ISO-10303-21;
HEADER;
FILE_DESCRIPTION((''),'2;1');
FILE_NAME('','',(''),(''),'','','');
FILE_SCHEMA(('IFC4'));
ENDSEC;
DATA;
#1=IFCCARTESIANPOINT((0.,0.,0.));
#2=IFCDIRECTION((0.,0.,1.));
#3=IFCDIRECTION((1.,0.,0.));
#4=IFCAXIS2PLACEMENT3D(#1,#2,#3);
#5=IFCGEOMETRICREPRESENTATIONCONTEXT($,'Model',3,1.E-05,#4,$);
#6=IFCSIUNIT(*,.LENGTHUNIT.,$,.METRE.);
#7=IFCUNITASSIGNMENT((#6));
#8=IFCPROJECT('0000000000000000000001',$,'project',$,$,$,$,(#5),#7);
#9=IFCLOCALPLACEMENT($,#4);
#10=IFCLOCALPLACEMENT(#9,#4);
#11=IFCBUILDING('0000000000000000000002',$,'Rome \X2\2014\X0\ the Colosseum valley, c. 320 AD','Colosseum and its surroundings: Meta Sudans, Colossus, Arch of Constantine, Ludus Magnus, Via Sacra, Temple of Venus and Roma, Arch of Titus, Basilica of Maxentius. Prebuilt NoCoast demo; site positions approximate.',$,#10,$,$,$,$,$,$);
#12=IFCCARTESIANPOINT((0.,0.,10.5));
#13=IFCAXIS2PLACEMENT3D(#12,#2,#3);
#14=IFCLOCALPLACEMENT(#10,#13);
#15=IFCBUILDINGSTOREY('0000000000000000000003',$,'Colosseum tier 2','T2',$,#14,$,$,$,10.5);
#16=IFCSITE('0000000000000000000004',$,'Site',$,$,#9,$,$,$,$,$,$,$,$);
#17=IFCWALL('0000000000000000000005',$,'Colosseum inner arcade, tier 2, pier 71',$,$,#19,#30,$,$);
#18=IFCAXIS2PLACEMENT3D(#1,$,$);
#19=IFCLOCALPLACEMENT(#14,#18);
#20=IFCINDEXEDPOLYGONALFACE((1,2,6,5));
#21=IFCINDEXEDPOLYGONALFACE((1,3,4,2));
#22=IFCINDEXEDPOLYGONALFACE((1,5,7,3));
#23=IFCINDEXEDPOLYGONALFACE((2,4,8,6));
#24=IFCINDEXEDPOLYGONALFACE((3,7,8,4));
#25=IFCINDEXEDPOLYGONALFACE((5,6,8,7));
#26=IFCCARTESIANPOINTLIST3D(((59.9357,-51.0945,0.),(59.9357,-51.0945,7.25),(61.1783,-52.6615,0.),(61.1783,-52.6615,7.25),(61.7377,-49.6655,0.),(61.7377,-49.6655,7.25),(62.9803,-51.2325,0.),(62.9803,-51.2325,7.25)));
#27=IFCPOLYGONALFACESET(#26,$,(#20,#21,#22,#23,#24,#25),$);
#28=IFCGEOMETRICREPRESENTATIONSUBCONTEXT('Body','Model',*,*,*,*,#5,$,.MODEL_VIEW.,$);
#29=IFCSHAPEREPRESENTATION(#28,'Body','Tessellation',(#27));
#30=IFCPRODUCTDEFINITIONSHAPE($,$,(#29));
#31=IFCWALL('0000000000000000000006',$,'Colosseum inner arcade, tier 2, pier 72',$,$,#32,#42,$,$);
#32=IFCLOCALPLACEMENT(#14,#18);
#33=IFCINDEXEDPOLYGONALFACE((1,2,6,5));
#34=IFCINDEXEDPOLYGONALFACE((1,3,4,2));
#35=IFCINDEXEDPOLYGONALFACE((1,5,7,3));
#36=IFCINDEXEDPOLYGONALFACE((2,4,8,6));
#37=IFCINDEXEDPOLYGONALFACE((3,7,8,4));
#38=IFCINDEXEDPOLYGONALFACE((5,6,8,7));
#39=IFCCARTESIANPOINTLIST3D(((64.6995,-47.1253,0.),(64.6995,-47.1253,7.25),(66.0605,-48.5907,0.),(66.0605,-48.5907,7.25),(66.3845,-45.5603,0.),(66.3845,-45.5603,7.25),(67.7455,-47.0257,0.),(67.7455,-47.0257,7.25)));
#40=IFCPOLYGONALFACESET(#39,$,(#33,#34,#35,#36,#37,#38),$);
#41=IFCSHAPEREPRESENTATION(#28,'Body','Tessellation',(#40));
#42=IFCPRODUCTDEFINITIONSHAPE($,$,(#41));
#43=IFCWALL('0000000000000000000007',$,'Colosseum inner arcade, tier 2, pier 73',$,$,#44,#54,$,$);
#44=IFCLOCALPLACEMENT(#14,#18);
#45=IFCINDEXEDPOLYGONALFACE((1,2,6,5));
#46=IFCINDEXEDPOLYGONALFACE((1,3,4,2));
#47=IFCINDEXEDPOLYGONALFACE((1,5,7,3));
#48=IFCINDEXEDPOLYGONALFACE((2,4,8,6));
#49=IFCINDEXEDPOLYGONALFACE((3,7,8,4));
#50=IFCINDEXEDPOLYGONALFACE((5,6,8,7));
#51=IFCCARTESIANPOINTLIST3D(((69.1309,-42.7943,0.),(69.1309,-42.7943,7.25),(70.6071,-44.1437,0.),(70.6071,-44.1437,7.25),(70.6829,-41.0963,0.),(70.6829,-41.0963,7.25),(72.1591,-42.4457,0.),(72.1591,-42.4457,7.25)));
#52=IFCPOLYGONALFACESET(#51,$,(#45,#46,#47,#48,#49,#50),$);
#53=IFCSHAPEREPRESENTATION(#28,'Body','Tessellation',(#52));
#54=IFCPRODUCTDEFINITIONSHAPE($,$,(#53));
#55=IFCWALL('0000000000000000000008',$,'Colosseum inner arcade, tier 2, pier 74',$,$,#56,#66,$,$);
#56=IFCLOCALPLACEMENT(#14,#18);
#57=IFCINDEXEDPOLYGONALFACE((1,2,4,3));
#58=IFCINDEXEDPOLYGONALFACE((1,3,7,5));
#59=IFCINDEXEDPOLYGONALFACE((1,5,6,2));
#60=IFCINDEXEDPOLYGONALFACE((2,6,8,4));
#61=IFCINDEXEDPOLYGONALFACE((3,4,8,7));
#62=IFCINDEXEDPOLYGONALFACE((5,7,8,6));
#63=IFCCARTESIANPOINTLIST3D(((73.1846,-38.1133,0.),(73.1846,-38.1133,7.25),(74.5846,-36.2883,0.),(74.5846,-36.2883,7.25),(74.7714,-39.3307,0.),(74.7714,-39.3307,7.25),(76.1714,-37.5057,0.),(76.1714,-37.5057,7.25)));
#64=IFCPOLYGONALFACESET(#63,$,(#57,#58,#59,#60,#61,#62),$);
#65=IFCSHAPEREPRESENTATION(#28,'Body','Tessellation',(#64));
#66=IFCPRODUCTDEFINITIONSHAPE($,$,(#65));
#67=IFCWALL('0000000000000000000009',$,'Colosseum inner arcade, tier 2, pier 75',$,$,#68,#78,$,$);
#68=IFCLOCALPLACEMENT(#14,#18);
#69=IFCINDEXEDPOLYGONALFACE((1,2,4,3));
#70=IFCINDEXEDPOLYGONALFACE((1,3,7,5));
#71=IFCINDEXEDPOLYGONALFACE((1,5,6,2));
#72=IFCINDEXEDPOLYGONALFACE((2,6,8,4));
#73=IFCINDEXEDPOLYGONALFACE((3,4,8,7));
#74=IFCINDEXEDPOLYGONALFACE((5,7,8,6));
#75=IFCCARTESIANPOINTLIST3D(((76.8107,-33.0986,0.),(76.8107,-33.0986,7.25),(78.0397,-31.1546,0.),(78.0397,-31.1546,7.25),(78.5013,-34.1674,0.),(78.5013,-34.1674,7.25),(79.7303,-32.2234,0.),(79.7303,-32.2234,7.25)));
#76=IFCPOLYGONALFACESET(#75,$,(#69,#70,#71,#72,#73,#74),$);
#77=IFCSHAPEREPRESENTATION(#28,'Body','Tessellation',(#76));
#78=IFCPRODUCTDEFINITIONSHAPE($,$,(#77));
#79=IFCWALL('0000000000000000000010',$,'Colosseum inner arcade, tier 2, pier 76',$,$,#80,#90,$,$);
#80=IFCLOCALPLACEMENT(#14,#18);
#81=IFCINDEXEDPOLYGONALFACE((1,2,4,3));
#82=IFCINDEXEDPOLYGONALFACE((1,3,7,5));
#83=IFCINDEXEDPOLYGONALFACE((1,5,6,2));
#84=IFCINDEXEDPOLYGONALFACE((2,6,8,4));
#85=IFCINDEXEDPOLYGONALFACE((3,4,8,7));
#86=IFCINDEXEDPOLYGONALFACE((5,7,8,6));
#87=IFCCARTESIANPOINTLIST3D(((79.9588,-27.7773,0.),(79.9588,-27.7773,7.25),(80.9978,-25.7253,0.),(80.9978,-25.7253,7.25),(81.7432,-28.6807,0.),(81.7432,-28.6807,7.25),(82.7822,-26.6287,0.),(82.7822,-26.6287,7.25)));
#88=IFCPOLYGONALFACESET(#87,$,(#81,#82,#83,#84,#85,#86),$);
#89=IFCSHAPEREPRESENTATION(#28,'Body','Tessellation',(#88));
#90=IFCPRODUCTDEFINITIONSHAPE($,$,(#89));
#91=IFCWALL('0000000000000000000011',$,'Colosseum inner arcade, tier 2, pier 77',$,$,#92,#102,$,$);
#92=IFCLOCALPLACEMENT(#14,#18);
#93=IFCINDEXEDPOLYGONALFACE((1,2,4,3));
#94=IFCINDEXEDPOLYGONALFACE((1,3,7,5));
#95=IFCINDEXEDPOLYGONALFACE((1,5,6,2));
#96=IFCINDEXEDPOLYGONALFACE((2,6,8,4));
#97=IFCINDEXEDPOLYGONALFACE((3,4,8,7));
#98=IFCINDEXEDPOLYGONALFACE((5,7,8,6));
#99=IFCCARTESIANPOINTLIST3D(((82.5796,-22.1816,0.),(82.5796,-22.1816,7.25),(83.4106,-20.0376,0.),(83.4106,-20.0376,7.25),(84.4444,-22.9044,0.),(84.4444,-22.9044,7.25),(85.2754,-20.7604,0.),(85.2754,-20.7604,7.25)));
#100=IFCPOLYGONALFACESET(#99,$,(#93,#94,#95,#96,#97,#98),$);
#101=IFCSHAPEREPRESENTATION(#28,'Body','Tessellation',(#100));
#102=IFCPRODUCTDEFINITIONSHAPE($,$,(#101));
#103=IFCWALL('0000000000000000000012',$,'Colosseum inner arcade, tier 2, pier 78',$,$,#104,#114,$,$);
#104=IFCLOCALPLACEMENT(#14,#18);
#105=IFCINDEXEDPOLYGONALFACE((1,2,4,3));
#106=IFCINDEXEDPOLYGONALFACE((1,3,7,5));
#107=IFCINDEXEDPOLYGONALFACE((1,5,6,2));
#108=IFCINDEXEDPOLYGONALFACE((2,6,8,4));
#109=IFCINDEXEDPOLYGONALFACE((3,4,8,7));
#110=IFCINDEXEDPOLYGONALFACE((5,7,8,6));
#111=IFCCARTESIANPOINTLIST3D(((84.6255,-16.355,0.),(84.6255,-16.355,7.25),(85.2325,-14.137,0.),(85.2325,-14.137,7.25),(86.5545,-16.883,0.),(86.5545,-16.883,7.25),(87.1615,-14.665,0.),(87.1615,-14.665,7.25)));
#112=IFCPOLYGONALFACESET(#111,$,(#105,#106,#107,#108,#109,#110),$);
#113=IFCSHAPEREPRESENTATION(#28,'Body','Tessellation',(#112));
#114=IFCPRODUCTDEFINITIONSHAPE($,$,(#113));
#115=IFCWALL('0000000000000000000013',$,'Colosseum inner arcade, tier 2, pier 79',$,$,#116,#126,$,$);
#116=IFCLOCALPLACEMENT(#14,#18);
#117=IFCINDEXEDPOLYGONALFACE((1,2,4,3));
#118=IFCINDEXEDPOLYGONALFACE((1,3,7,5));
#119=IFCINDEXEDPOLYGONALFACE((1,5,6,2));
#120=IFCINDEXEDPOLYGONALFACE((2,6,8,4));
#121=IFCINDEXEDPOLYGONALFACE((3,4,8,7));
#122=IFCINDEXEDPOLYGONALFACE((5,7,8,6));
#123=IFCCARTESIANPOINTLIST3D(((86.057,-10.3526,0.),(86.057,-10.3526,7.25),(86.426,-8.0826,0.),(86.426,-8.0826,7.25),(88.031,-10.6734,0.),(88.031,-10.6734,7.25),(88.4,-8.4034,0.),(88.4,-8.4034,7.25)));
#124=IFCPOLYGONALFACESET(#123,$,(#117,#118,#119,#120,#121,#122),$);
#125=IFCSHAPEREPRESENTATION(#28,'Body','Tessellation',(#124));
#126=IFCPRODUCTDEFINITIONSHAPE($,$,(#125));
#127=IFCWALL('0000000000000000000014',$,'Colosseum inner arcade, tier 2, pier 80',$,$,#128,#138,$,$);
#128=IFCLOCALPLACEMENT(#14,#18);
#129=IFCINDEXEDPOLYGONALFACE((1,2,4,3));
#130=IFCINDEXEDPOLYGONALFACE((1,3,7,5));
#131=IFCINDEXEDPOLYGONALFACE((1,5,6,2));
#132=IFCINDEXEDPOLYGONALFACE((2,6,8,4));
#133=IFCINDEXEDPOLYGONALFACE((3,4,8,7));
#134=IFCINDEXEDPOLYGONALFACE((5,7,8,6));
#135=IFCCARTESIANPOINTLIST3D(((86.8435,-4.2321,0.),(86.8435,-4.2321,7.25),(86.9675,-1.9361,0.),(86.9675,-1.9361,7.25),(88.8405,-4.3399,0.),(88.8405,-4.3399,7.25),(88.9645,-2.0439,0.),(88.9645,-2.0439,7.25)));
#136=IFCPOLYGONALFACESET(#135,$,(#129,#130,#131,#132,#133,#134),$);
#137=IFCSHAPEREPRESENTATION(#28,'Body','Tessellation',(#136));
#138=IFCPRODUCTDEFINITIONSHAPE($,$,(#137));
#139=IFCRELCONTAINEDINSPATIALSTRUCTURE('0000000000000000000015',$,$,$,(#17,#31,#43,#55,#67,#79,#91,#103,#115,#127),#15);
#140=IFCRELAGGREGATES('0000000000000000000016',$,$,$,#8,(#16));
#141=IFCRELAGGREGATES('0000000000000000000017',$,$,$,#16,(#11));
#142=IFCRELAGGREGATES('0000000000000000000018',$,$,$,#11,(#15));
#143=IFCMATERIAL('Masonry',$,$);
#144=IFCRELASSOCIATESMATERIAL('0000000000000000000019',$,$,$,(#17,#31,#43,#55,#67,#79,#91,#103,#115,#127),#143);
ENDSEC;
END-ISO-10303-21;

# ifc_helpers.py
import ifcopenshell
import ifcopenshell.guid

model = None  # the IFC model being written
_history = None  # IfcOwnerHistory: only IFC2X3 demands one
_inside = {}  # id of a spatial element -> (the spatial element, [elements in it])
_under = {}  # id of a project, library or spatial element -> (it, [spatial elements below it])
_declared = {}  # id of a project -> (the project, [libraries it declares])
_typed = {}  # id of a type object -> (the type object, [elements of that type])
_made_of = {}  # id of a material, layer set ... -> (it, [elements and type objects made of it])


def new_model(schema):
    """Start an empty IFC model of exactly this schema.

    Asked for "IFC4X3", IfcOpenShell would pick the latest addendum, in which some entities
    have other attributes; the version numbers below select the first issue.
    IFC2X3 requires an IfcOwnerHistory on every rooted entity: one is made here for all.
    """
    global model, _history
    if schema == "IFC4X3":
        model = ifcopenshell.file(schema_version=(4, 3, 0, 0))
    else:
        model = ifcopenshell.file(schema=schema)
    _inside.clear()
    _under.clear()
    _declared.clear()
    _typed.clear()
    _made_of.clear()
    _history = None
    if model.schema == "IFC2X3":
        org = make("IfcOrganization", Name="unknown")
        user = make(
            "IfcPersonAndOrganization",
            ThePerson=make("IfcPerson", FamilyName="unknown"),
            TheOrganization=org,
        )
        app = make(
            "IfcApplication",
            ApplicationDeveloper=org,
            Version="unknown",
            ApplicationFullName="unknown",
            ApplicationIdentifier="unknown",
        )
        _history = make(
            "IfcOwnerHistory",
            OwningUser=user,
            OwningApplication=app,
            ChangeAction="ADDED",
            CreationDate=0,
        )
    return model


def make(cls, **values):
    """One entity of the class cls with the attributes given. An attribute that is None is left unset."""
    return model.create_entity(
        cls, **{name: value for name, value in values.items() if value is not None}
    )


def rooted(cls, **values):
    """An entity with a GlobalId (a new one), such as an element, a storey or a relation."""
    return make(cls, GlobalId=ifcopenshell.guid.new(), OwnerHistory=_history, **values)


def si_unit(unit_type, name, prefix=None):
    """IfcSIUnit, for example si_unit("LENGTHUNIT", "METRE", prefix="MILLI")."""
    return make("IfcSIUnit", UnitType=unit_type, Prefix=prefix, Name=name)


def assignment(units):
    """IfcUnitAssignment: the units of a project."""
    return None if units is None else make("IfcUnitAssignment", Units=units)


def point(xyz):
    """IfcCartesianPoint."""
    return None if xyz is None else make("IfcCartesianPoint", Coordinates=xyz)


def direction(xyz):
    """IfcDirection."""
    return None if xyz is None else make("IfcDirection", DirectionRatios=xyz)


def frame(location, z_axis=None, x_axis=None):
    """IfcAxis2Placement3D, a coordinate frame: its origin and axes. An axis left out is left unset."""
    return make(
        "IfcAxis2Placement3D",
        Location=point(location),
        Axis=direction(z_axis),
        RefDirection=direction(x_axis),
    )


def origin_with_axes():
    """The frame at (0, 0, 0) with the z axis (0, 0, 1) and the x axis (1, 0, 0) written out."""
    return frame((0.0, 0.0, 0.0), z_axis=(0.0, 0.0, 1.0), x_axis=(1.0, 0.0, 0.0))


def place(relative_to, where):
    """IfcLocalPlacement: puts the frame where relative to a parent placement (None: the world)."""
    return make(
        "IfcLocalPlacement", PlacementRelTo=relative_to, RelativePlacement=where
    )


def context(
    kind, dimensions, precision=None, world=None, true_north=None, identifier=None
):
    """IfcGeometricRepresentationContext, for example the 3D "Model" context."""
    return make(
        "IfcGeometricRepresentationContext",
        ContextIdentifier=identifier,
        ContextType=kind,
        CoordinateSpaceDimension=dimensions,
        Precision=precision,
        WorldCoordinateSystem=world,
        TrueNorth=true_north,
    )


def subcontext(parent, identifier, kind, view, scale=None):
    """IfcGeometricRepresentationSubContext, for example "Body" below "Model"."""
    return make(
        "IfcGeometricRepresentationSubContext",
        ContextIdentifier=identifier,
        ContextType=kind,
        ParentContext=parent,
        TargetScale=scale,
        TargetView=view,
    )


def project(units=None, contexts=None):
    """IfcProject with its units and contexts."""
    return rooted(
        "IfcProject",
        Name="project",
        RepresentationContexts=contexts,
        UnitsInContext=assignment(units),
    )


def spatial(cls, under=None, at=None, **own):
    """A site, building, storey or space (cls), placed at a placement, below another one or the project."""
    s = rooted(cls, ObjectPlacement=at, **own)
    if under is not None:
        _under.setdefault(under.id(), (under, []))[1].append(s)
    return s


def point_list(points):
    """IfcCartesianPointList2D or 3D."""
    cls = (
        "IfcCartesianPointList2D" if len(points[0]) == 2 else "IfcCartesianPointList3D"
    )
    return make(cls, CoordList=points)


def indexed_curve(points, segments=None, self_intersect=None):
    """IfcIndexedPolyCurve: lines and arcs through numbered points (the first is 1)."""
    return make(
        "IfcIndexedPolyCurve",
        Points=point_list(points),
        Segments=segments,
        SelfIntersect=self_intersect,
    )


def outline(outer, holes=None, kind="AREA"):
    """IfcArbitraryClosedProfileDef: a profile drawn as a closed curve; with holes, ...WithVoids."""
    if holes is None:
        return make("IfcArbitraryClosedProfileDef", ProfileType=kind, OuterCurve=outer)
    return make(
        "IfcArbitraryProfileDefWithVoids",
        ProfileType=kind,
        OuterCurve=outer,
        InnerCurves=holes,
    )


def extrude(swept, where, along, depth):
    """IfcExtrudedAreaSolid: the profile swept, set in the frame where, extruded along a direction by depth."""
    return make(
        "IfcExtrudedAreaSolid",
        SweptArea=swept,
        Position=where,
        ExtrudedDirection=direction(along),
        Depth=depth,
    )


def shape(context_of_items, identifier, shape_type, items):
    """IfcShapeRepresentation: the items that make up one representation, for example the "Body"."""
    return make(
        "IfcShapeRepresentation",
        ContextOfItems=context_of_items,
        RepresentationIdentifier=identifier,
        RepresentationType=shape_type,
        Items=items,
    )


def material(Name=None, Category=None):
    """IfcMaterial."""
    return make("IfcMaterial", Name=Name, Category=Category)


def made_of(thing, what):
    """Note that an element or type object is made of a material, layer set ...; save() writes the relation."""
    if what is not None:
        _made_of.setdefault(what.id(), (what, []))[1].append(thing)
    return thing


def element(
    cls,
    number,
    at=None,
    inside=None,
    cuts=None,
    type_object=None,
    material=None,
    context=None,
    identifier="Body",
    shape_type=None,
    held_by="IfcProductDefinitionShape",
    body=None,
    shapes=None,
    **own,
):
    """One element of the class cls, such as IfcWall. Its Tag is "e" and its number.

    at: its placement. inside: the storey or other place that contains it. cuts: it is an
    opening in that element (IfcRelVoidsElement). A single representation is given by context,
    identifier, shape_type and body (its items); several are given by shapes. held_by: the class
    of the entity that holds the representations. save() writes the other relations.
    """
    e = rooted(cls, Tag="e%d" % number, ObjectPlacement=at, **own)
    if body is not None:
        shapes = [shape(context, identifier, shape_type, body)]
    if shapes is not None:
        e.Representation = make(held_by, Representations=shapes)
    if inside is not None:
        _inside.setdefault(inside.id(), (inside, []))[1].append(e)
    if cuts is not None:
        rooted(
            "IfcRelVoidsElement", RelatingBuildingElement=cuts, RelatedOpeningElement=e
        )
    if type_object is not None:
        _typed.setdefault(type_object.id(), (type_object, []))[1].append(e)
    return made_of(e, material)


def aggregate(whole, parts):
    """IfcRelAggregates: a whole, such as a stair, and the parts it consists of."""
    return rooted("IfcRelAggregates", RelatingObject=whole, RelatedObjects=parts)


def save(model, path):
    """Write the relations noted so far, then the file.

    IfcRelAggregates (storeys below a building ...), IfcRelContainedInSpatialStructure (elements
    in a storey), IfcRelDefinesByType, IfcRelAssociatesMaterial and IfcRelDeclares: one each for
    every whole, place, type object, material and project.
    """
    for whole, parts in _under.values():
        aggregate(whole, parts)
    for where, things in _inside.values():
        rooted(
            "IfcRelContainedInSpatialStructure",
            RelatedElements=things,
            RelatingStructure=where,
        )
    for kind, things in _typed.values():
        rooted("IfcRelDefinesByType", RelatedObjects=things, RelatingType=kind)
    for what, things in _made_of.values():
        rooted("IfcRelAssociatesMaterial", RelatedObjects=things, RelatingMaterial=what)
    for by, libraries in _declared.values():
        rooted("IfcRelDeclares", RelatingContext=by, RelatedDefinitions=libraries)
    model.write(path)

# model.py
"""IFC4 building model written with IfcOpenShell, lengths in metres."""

from ifc_helpers import new_model, si_unit, frame, origin_with_axes, place, context, subcontext, project, spatial, indexed_curve, outline, extrude, material, element, save


model = new_model("IFC4")

# Units and contexts
model_context = context("Model", 3, precision=1e-05, world=origin_with_axes())
body_context = subcontext(model_context, "Body", "Model", "MODEL_VIEW")
ifc_project = project(units=[si_unit("LENGTHUNIT", "METRE")], contexts=[model_context])

# Site, building, storey
site_placement = place(None, origin_with_axes())
site = spatial("IfcSite", under=ifc_project, at=site_placement, Name="Site")
building_placement = place(site_placement, origin_with_axes())
building = spatial("IfcBuilding", under=site, at=building_placement, Name="Rome — the Colosseum valley, c. 320 AD", Description="Colosseum and its surroundings: Meta Sudans, Colossus, Arch of Constantine, Ludus Magnus, Via Sacra, Temple of Venus and Roma, Arch of Titus, Basilica of Maxentius. Prebuilt NoCoast demo; site positions approximate.")
storey_placement = place(building_placement, frame((0.0, 0.0, 10.5), z_axis=(0.0, 0.0, 1.0), x_axis=(1.0, 0.0, 0.0)))
storey = spatial("IfcBuildingStorey", under=building, at=storey_placement, Name="Colosseum tier 2", Description="T2", Elevation=10.5)

# Walls
ifc_material = material(Name="Masonry")
wall_1_placement = place(storey_placement, frame((60.557, -51.878, 0.0), z_axis=(0.0, 0.0, 1.0), x_axis=(0.783534, 0.621349, 0.0)))
element("IfcWall", 1, at=wall_1_placement, inside=storey, material=ifc_material, Name="Colosseum inner arcade, tier 2, pier 71", context=body_context, shape_type="SweptSolid", body=[
    extrude(outline(indexed_curve([(0.0, 0.0), (0.0, 2.0), (2.2998, 2.0), (2.2998, 0.0), (0.0, 0.0)], self_intersect=False)), frame((0.0, -1.0, 0.0), z_axis=(0.0, 0.0, 1.0), x_axis=(1.0, 0.0, 0.0)), (0.0, 0.0, 1.0), 7.25),
])
wall_2_placement = place(storey_placement, frame((65.38, -47.858, 0.0), z_axis=(0.0, 0.0, 1.0), x_axis=(0.732716, 0.680534, 0.0)))
element("IfcWall", 2, at=wall_2_placement, inside=storey, material=ifc_material, Name="Colosseum inner arcade, tier 2, pier 72", context=body_context, shape_type="SweptSolid", body=[
    extrude(outline(indexed_curve([(0.0, 0.0), (0.0, 2.0), (2.2997, 2.0), (2.2997, 0.0), (0.0, 0.0)], self_intersect=False)), frame((0.0, -1.0, 0.0), z_axis=(0.0, 0.0, 1.0), x_axis=(1.0, 0.0, 0.0)), (0.0, 0.0, 1.0), 7.25),
])
wall_3_placement = place(storey_placement, frame((69.869, -43.469, 0.0), z_axis=(0.0, 0.0, 1.0), x_axis=(0.674661, 0.738128, 0.0)))
element("IfcWall", 3, at=wall_3_placement, inside=storey, material=ifc_material, Name="Colosseum inner arcade, tier 2, pier 73", context=body_context, shape_type="SweptSolid", body=[
    extrude(outline(indexed_curve([(0.0, 0.0), (0.0, 2.0), (2.3004, 2.0), (2.3004, 0.0), (0.0, 0.0)], self_intersect=False)), frame((0.0, -1.0, 0.0), z_axis=(0.0, 0.0, 1.0), x_axis=(1.0, 0.0, 0.0)), (0.0, 0.0, 1.0), 7.25),
])
wall_4_placement = place(storey_placement, frame((73.978, -38.722, 0.0), z_axis=(0.0, 0.0, 1.0), x_axis=(0.60866, 0.793431, 0.0)))
element("IfcWall", 4, at=wall_4_placement, inside=storey, material=ifc_material, Name="Colosseum inner arcade, tier 2, pier 74", context=body_context, shape_type="SweptSolid", body=[
    extrude(outline(indexed_curve([(0.0, 0.0), (0.0, 2.0), (2.3001, 2.0), (2.3001, 0.0), (0.0, 0.0)], self_intersect=False)), frame((0.0, -1.0, 0.0), z_axis=(0.0, 0.0, 1.0), x_axis=(1.0, 0.0, 0.0)), (0.0, 0.0, 1.0), 7.25),
])
wall_5_placement = place(storey_placement, frame((77.656, -33.633, 0.0), z_axis=(0.0, 0.0, 1.0), x_axis=(0.534369, 0.845251, 0.0)))
element("IfcWall", 5, at=wall_5_placement, inside=storey, material=ifc_material, Name="Colosseum inner arcade, tier 2, pier 75", context=body_context, shape_type="SweptSolid", body=[
    extrude(outline(indexed_curve([(0.0, 0.0), (0.0, 2.0), (2.2999, 2.0), (2.2999, 0.0), (0.0, 0.0)], self_intersect=False)), frame((0.0, -1.0, 0.0), z_axis=(0.0, 0.0, 1.0), x_axis=(1.0, 0.0, 0.0)), (0.0, 0.0, 1.0), 7.25),
])
wall_6_placement = place(storey_placement, frame((80.851, -28.229, 0.0), z_axis=(0.0, 0.0, 1.0), x_axis=(0.45173, 0.892155, 0.0)))
element("IfcWall", 6, at=wall_6_placement, inside=storey, material=ifc_material, Name="Colosseum inner arcade, tier 2, pier 76", context=body_context, shape_type="SweptSolid", body=[
    extrude(outline(indexed_curve([(0.0, 0.0), (0.0, 2.0), (2.3, 2.0), (2.3, 0.0), (0.0, 0.0)], self_intersect=False)), frame((0.0, -1.0, 0.0), z_axis=(0.0, 0.0, 1.0), x_axis=(1.0, 0.0, 0.0)), (0.0, 0.0, 1.0), 7.25),
])
wall_7_placement = place(storey_placement, frame((83.512, -22.543, 0.0), z_axis=(0.0, 0.0, 1.0), x_axis=(0.361397, 0.932412, 0.0)))
element("IfcWall", 7, at=wall_7_placement, inside=storey, material=ifc_material, Name="Colosseum inner arcade, tier 2, pier 77", context=body_context, shape_type="SweptSolid", body=[
    extrude(outline(indexed_curve([(0.0, 0.0), (0.0, 2.0), (2.2994, 2.0), (2.2994, 0.0), (0.0, 0.0)], self_intersect=False)), frame((0.0, -1.0, 0.0), z_axis=(0.0, 0.0, 1.0), x_axis=(1.0, 0.0, 0.0)), (0.0, 0.0, 1.0), 7.25),
])
wall_8_placement = place(storey_placement, frame((85.59, -16.619, 0.0), z_axis=(0.0, 0.0, 1.0), x_axis=(0.263964, 0.964533, 0.0)))
element("IfcWall", 8, at=wall_8_placement, inside=storey, material=ifc_material, Name="Colosseum inner arcade, tier 2, pier 78", context=body_context, shape_type="SweptSolid", body=[
    extrude(outline(indexed_curve([(0.0, 0.0), (0.0, 2.0), (2.2996, 2.0), (2.2996, 0.0), (0.0, 0.0)], self_intersect=False)), frame((0.0, -1.0, 0.0), z_axis=(0.0, 0.0, 1.0), x_axis=(1.0, 0.0, 0.0)), (0.0, 0.0, 1.0), 7.25),
])
wall_9_placement = place(storey_placement, frame((87.044, -10.513, 0.0), z_axis=(0.0, 0.0, 1.0), x_axis=(0.160449, 0.987044, 0.0)))
element("IfcWall", 9, at=wall_9_placement, inside=storey, material=ifc_material, Name="Colosseum inner arcade, tier 2, pier 79", context=body_context, shape_type="SweptSolid", body=[
    extrude(outline(indexed_curve([(0.0, 0.0), (0.0, 2.0), (2.2998, 2.0), (2.2998, 0.0), (0.0, 0.0)], self_intersect=False)), frame((0.0, -1.0, 0.0), z_axis=(0.0, 0.0, 1.0), x_axis=(1.0, 0.0, 0.0)), (0.0, 0.0, 1.0), 7.25),
])
wall_10_placement = place(storey_placement, frame((87.842, -4.286, 0.0), z_axis=(0.0, 0.0, 1.0), x_axis=(0.053928, 0.998545, 0.0)))
element("IfcWall", 10, at=wall_10_placement, inside=storey, material=ifc_material, Name="Colosseum inner arcade, tier 2, pier 80", context=body_context, shape_type="SweptSolid", body=[
    extrude(outline(indexed_curve([(0.0, 0.0), (0.0, 2.0), (2.2993, 2.0), (2.2993, 0.0), (0.0, 0.0)], self_intersect=False)), frame((0.0, -1.0, 0.0), z_axis=(0.0, 0.0, 1.0), x_axis=(1.0, 0.0, 0.0)), (0.0, 0.0, 1.0), 7.25),
])

save(model, "model.ifc")
